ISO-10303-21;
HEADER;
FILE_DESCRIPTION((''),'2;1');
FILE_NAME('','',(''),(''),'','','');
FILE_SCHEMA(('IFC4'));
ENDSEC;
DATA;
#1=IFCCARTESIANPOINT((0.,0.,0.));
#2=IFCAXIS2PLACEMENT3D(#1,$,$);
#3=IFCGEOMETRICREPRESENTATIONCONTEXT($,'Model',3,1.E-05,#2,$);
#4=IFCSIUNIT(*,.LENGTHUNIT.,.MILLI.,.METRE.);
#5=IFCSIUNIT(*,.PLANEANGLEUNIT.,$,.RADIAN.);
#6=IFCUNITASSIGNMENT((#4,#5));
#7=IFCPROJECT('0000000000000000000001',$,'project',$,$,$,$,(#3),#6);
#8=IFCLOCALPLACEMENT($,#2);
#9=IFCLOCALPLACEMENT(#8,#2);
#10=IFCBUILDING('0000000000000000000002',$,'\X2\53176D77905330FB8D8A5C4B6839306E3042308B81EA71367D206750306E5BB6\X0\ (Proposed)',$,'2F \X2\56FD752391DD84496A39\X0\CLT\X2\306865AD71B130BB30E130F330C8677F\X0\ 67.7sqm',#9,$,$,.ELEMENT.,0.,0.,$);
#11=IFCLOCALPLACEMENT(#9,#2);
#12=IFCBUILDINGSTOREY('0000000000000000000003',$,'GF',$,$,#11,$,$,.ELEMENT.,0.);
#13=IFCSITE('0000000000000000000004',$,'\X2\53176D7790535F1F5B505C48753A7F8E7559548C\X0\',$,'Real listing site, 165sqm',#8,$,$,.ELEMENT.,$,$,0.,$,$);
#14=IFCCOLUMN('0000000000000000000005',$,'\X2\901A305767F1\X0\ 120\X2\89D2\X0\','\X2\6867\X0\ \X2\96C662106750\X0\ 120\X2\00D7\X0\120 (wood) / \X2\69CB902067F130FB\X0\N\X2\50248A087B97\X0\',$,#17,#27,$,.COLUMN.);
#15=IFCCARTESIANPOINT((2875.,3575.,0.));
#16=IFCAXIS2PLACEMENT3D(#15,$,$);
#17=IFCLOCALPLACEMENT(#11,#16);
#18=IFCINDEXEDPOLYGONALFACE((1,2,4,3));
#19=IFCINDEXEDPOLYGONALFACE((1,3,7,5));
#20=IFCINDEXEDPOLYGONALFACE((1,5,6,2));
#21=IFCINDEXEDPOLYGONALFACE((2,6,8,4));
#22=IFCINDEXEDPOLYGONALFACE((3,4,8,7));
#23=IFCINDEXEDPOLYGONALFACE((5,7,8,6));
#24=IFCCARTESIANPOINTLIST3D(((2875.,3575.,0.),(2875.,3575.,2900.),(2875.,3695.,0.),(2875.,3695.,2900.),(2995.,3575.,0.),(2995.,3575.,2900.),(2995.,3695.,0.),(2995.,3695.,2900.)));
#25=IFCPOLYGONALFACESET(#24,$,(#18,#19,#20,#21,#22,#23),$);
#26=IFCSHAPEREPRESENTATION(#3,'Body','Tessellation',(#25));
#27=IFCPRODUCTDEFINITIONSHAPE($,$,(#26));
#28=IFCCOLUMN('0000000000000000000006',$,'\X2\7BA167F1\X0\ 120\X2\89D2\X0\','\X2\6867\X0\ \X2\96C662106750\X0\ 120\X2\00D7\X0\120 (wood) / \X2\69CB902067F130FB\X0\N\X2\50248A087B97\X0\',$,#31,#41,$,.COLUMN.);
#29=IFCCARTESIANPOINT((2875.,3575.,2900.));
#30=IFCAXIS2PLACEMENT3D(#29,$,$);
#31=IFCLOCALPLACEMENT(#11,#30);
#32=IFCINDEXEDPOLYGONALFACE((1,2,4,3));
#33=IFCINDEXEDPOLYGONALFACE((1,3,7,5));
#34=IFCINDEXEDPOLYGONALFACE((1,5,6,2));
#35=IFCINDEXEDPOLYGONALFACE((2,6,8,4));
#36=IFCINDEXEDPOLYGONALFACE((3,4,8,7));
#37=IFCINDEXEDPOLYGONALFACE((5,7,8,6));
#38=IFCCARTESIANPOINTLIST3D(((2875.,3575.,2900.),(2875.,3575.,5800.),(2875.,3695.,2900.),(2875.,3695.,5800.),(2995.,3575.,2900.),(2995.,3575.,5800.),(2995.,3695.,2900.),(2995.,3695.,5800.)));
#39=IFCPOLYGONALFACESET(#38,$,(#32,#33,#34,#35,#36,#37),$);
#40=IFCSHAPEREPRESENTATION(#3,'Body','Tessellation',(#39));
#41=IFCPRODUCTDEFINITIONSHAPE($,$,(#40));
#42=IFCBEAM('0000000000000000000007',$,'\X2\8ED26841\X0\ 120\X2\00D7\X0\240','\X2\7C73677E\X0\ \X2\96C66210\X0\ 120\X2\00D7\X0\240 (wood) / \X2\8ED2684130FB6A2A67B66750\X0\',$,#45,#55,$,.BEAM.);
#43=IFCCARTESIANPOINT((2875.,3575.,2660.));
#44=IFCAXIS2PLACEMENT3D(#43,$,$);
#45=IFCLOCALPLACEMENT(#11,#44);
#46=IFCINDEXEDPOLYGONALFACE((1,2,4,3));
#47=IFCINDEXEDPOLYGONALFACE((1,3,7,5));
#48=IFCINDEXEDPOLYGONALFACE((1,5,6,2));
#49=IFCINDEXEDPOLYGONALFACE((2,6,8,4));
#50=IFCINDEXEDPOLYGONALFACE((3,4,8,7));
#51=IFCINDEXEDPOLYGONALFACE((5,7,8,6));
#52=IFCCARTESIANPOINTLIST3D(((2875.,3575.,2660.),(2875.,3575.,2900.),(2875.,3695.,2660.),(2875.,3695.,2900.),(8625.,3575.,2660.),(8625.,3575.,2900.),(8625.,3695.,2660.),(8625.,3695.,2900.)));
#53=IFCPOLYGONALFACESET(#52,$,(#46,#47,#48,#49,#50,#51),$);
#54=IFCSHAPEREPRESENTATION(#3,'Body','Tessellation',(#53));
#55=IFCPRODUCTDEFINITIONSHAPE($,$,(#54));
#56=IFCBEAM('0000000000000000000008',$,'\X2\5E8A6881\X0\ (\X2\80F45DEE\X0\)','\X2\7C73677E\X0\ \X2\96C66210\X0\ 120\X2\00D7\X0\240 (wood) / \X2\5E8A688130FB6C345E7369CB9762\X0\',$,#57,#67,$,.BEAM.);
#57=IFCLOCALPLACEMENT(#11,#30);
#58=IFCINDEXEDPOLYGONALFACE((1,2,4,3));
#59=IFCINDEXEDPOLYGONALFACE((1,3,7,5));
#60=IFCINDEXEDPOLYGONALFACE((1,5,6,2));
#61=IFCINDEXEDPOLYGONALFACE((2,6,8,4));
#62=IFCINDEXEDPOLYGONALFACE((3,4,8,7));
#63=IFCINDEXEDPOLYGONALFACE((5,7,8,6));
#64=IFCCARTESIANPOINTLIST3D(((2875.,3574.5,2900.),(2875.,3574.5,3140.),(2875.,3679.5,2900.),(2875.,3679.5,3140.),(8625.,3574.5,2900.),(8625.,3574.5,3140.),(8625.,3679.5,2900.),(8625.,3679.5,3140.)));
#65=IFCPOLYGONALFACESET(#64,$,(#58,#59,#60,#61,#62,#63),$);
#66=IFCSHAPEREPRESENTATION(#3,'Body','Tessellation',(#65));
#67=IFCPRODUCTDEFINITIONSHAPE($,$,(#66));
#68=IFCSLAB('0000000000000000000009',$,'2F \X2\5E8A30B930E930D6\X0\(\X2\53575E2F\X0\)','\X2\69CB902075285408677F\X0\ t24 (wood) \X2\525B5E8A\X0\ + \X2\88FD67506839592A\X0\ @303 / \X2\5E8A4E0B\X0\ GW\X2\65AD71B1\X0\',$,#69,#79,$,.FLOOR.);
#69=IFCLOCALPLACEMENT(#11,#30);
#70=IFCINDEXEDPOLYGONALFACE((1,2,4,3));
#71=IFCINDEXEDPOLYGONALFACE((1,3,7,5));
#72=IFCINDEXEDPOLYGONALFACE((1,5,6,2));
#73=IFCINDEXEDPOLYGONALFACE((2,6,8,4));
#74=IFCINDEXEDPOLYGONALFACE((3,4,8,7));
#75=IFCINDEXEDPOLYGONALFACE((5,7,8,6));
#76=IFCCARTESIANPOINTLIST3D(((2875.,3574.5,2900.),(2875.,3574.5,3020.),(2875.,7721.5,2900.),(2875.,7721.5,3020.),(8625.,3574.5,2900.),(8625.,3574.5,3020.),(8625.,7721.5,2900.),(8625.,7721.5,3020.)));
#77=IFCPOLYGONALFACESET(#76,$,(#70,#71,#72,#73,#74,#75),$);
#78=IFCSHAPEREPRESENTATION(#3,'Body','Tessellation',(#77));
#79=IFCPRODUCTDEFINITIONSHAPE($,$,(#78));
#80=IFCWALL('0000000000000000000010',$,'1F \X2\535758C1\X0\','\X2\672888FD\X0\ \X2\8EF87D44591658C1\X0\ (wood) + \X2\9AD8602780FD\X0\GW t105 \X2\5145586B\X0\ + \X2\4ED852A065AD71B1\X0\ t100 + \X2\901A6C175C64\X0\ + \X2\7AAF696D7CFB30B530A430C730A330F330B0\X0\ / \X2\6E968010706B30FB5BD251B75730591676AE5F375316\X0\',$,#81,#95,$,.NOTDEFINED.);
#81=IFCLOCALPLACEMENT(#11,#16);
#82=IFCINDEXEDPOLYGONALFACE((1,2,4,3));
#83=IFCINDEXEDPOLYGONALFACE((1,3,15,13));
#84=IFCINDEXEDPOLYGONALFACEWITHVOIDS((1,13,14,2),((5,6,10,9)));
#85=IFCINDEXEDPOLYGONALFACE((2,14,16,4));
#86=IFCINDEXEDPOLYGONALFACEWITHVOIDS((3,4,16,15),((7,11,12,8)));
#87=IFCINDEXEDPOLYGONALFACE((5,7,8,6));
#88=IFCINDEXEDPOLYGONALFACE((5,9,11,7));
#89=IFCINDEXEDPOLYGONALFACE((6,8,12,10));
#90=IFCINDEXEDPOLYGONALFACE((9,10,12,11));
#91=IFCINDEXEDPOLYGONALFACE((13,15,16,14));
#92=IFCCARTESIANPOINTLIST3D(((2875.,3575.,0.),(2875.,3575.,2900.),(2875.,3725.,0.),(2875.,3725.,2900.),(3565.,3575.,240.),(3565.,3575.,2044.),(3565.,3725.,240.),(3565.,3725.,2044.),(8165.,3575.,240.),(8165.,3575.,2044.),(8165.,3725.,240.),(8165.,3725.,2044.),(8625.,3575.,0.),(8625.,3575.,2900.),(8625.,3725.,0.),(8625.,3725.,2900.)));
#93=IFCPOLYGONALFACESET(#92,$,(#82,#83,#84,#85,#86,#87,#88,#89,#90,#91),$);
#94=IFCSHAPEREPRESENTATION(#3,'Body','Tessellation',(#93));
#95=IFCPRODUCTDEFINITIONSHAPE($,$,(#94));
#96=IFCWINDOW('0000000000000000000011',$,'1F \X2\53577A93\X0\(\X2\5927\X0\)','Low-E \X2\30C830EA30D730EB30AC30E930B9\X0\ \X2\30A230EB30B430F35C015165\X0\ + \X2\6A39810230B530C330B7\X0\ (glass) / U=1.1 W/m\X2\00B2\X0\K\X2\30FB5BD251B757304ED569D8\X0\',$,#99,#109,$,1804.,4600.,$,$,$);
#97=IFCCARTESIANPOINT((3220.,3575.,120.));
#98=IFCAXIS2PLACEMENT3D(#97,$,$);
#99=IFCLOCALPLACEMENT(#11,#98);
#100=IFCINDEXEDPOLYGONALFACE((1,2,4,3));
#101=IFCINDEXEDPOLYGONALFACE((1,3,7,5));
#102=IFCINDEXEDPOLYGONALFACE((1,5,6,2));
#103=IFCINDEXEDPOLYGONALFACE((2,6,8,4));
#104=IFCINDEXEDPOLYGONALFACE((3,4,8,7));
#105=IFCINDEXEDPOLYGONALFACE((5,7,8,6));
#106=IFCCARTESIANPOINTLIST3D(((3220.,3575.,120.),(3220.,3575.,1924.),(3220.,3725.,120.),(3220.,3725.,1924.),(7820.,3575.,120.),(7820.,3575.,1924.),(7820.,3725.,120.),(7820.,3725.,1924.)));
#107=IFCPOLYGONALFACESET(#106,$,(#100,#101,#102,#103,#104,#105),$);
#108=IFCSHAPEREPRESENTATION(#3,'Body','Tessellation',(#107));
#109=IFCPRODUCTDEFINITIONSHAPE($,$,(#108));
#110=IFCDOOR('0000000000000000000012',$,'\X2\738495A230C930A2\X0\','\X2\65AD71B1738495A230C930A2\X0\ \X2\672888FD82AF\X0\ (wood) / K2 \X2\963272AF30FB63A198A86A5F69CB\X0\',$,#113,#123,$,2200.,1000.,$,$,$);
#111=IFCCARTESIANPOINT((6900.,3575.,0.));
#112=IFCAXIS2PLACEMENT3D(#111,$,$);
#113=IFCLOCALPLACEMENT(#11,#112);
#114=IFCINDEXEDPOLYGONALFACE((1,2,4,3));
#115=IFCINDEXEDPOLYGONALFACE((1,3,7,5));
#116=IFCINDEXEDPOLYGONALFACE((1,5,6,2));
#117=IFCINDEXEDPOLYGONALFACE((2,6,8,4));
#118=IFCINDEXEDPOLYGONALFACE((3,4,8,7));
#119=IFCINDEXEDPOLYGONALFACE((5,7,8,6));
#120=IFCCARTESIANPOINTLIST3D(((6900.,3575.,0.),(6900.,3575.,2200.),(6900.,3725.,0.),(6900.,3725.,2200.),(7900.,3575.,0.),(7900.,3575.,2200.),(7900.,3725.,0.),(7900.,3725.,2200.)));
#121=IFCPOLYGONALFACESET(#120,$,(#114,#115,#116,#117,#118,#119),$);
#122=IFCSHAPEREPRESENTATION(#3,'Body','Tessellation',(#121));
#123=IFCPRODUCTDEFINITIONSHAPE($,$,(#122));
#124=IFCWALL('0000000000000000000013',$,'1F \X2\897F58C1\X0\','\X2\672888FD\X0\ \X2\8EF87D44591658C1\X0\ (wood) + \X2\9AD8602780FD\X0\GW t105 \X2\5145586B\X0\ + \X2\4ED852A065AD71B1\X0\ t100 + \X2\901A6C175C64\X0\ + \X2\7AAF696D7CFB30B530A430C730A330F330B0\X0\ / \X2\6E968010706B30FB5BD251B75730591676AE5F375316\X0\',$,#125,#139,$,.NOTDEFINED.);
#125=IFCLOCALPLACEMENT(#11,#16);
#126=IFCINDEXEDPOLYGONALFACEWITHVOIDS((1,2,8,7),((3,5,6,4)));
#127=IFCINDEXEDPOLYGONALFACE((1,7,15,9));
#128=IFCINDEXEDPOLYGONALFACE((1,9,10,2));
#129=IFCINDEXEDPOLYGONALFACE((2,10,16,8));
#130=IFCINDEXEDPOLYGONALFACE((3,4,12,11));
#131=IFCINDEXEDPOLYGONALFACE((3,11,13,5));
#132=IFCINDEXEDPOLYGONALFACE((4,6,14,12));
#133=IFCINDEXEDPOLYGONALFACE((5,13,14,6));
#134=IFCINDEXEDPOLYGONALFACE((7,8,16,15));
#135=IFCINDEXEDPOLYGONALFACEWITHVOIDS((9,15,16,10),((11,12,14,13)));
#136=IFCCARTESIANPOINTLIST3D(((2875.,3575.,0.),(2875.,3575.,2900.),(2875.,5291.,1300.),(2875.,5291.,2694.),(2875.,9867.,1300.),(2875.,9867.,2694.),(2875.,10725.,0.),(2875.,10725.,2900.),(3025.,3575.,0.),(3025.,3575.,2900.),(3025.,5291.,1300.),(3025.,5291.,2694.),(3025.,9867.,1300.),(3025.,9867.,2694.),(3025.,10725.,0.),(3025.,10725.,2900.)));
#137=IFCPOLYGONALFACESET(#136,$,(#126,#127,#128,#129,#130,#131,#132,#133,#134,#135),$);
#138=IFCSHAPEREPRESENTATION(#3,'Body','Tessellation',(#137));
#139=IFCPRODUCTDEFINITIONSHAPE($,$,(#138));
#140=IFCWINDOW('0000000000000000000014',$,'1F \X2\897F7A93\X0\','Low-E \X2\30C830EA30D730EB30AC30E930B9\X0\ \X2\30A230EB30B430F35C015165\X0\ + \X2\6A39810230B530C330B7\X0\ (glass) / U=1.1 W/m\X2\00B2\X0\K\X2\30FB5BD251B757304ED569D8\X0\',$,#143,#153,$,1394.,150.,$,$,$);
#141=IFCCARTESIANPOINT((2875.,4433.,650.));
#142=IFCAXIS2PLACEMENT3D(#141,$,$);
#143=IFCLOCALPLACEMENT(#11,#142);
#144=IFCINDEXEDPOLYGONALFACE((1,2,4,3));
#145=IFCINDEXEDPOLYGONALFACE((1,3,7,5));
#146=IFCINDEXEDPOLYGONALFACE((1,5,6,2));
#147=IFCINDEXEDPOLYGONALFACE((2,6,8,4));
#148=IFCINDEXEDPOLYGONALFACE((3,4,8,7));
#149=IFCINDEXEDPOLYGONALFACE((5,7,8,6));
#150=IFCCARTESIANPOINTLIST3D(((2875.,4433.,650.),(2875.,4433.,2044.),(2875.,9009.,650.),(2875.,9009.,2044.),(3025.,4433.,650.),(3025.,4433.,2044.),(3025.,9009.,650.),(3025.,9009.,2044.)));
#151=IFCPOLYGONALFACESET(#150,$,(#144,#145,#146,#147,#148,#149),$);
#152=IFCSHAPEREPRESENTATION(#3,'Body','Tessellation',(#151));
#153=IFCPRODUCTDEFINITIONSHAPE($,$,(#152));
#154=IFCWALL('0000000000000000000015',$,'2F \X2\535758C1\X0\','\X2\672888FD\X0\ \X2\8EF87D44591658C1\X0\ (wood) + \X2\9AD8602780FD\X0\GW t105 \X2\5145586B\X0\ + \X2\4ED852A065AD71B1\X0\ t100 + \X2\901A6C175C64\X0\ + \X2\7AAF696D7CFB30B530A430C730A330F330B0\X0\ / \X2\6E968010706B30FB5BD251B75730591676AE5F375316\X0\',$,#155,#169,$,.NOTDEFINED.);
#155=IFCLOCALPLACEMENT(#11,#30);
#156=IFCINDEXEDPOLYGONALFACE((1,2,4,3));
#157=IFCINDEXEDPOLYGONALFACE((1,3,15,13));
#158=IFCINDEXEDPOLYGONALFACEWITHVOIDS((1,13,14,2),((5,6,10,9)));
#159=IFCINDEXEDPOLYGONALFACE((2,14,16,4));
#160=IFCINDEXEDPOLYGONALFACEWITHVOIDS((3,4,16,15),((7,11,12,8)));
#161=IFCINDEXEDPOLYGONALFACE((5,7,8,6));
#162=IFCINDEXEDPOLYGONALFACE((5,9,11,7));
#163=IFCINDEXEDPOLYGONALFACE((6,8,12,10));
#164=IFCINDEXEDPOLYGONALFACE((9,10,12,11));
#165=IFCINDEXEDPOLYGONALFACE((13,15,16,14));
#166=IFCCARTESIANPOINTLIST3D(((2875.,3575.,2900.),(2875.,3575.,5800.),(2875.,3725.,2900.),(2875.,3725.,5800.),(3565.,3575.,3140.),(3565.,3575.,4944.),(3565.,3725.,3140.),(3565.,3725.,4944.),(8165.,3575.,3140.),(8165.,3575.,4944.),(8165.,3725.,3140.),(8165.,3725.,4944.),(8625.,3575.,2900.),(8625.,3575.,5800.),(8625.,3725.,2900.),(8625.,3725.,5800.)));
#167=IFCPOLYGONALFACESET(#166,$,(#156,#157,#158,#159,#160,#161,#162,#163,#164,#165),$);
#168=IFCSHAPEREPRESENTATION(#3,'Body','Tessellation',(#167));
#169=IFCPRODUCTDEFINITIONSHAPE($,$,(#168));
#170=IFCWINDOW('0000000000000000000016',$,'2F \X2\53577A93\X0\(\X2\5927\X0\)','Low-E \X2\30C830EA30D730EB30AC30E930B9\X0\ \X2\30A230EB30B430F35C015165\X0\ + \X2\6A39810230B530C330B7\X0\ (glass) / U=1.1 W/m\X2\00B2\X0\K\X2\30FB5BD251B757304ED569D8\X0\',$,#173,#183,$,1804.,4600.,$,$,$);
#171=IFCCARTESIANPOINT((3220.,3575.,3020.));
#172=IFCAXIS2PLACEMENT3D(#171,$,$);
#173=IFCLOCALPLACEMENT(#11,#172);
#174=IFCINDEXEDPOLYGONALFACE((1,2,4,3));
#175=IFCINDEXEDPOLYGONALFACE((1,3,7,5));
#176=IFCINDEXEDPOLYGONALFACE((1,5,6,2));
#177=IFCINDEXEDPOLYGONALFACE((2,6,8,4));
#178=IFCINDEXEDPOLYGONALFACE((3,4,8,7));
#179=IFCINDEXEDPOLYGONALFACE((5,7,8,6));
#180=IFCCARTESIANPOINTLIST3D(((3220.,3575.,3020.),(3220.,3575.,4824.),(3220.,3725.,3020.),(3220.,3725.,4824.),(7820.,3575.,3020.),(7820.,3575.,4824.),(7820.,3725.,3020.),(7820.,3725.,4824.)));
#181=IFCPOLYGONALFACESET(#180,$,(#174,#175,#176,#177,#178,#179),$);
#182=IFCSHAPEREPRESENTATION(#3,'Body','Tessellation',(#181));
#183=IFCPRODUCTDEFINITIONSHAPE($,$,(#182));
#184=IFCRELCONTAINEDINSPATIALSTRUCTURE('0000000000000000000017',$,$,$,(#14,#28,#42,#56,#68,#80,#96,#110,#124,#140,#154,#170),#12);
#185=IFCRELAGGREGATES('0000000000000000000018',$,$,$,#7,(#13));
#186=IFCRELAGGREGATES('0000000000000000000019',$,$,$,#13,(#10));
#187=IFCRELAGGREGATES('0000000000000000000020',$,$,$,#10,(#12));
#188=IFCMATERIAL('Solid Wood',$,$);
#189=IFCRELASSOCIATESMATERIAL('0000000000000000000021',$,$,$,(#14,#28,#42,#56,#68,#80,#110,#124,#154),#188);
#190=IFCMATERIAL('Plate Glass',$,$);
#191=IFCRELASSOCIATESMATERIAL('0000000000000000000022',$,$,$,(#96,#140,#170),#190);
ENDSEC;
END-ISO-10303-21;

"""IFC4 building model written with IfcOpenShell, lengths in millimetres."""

from ifc_helpers import new_model, si_unit, frame, frame_2d, origin, place, context, project, spatial, rectangle, extrude, material, element, fill, save


model = new_model("IFC4")

# Units and contexts
model_context = context("Model", 3, precision=1e-05, world=origin())
ifc_project = project(units=[si_unit("LENGTHUNIT", "METRE", prefix="MILLI"), si_unit("PLANEANGLEUNIT", "RADIAN")], contexts=[model_context])

# Site, building, storey
site_placement = place(None, origin())
site = spatial("IfcSite", under=ifc_project, at=site_placement, Name="北海道弟子屈町美留和", ObjectType="Real listing site, 165sqm", CompositionType="ELEMENT", RefElevation=0.0)
building_placement = place(site_placement, origin())
building = spatial("IfcBuilding", under=site, at=building_placement, Name="北海道・越屋根のある自然素材の家 (Proposed)", ObjectType="2F 国産針葉樹CLTと断熱セメント板 67.7sqm", CompositionType="ELEMENT", ElevationOfRefHeight=0.0, ElevationOfTerrain=0.0)
storey_placement = place(building_placement, origin())
storey = spatial("IfcBuildingStorey", under=building, at=storey_placement, Name="GF", CompositionType="ELEMENT", Elevation=0.0)

# Columns
ifc_material_1 = material(Name="Solid Wood")
column_1_placement = place(storey_placement, frame((2875.0, 3575.0, 0.0)))
element("IfcColumn", 1, at=column_1_placement, inside=storey, material=ifc_material_1, Name="通し柱 120角", Description="桧 集成材 120×120 (wood) / 構造柱・N値計算", PredefinedType="COLUMN", context=model_context, shape_type="SweptSolid", body=[
    extrude(rectangle(XDim=120.0, YDim=120.0, at=frame_2d((60.0, 60.0))), frame((2875.0, 3575.0, 0.0)), (0.0, 0.0, 1.0), 2900.0),
])
column_2_placement = place(storey_placement, frame((2875.0, 3575.0, 2900.0)))
element("IfcColumn", 2, at=column_2_placement, inside=storey, material=ifc_material_1, Name="管柱 120角", Description="桧 集成材 120×120 (wood) / 構造柱・N値計算", PredefinedType="COLUMN", context=model_context, shape_type="SweptSolid", body=[
    extrude(rectangle(XDim=120.0, YDim=120.0, at=frame_2d((60.0, 60.0))), frame((2875.0, 3575.0, 2900.0)), (0.0, 0.0, 1.0), 2900.0),
])

# Beams
beam_1_placement = place(storey_placement, frame((2875.0, 3575.0, 2660.0)))
element("IfcBeam", 3, at=beam_1_placement, inside=storey, material=ifc_material_1, Name="軒桁 120×240", Description="米松 集成 120×240 (wood) / 軒桁・横架材", PredefinedType="BEAM", context=model_context, shape_type="SweptSolid", body=[
    extrude(rectangle(XDim=5750.0, YDim=120.0, at=frame_2d((2875.0, 60.0))), frame((2875.0, 3575.0, 2660.0)), (0.0, 0.0, 1.0), 240.0),
])
beam_2_placement = place(storey_placement, frame((2875.0, 3575.0, 2900.0)))
element("IfcBeam", 4, at=beam_2_placement, inside=storey, material=ifc_material_1, Name="床梁 (胴差)", Description="米松 集成 120×240 (wood) / 床梁・水平構面", PredefinedType="BEAM", context=model_context, shape_type="SweptSolid", body=[
    extrude(rectangle(XDim=5750.0, YDim=105.0, at=frame_2d((2875.0, 52.0))), frame((2875.0, 3575.0, 2900.0)), (0.0, 0.0, 1.0), 240.0),
])

# Slab
slab_1_placement = place(storey_placement, frame((2875.0, 3575.0, 2900.0)))
element("IfcSlab", 5, at=slab_1_placement, inside=storey, material=ifc_material_1, Name="2F 床スラブ(南帯)", Description="構造用合板 t24 (wood) 剛床 + 製材根太 @303 / 床下 GW断熱", PredefinedType="FLOOR", context=model_context, shape_type="SweptSolid", body=[
    extrude(rectangle(XDim=5750.0, YDim=4147.0, at=frame_2d((2875.0, 2073.0))), frame((2875.0, 3575.0, 2900.0)), (0.0, 0.0, 1.0), 120.0),
])

# Wall, openings, window, door
wall_1_placement = place(storey_placement, frame((2875.0, 3575.0, 0.0)))
wall_1 = element("IfcWall", 6, at=wall_1_placement, inside=storey, material=ifc_material_1, Name="1F 南壁", Description="木製 軸組外壁 (wood) + 高性能GW t105 充填 + 付加断熱 t100 + 通気層 + 窯業系サイディング / 準耐火・寒冷地外皮強化", PredefinedType="NOTDEFINED", context=model_context, shape_type="SweptSolid", body=[
    extrude(rectangle(XDim=5750.0, YDim=150.0, at=frame_2d((2875.0, 75.0))), frame((2875.0, 3575.0, 0.0)), (0.0, 0.0, 1.0), 2900.0),
])
opening_1_placement = place(storey_placement, frame((3220.0, 3575.0, 120.0)))
opening_1 = element("IfcOpeningElement", 7, at=opening_1_placement, cuts=wall_1, PredefinedType="NOTDEFINED", context=model_context, shape_type="SweptSolid", body=[
    extrude(rectangle(XDim=4600.0, YDim=150.0, at=frame_2d((2300.0, 75.0))), frame((3220.0, 3575.0, 120.0)), (0.0, 0.0, 1.0), 1804.0),
])
opening_2_placement = place(storey_placement, frame((6900.0, 3575.0, 0.0)))
opening_2 = element("IfcOpeningElement", 8, at=opening_2_placement, cuts=wall_1, PredefinedType="NOTDEFINED", context=model_context, shape_type="SweptSolid", body=[
    extrude(rectangle(XDim=1000.0, YDim=150.0, at=frame_2d((500.0, 75.0))), frame((6900.0, 3575.0, 0.0)), (0.0, 0.0, 1.0), 2200.0),
])
ifc_material_2 = material(Name="Plate Glass")
window_1_placement = place(storey_placement, frame((3220.0, 3575.0, 120.0)))
window_1 = element("IfcWindow", 9, at=window_1_placement, inside=storey, material=ifc_material_2, Name="1F 南窓(大)", Description="Low-E トリプルガラス アルゴン封入 + 樹脂サッシ (glass) / U=1.1 W/m²K・寒冷地仕様", OverallHeight=1804.0, OverallWidth=4600.0, context=model_context, shape_type="SweptSolid", body=[
    extrude(rectangle(XDim=4600.0, YDim=150.0, at=frame_2d((2300.0, 75.0))), frame((3220.0, 3575.0, 120.0)), (0.0, 0.0, 1.0), 1804.0),
])
fill(opening_1, window_1)
door_placement = place(storey_placement, frame((6900.0, 3575.0, 0.0)))
door = element("IfcDoor", 10, at=door_placement, inside=storey, material=ifc_material_1, Name="玄関ドア", Description="断熱玄関ドア 木製芯 (wood) / K2 防犯・採風機構", OverallHeight=2200.0, OverallWidth=1000.0, context=model_context, shape_type="SweptSolid", body=[
    extrude(rectangle(XDim=1000.0, YDim=150.0, at=frame_2d((500.0, 75.0))), frame((6900.0, 3575.0, 0.0)), (0.0, 0.0, 1.0), 2200.0),
])
fill(opening_2, door)

# Walls, openings, windows
wall_2_placement = place(storey_placement, frame((2875.0, 3575.0, 0.0)))
wall_2 = element("IfcWall", 11, at=wall_2_placement, inside=storey, material=ifc_material_1, Name="1F 西壁", Description="木製 軸組外壁 (wood) + 高性能GW t105 充填 + 付加断熱 t100 + 通気層 + 窯業系サイディング / 準耐火・寒冷地外皮強化", PredefinedType="NOTDEFINED", context=model_context, shape_type="SweptSolid", body=[
    extrude(rectangle(XDim=150.0, YDim=7150.0, at=frame_2d((75.0, 3575.0))), frame((2875.0, 3575.0, 0.0)), (0.0, 0.0, 1.0), 2900.0),
])
opening_3_placement = place(storey_placement, frame((2875.0, 4433.0, 650.0)))
opening_3 = element("IfcOpeningElement", 12, at=opening_3_placement, cuts=wall_2, PredefinedType="NOTDEFINED", context=model_context, shape_type="SweptSolid", body=[
    extrude(rectangle(XDim=150.0, YDim=4576.0, at=frame_2d((75.0, 2288.0))), frame((2875.0, 4433.0, 650.0)), (0.0, 0.0, 1.0), 1394.0),
])
window_2_placement = place(storey_placement, frame((2875.0, 4433.0, 650.0)))
window_2 = element("IfcWindow", 13, at=window_2_placement, inside=storey, material=ifc_material_2, Name="1F 西窓", Description="Low-E トリプルガラス アルゴン封入 + 樹脂サッシ (glass) / U=1.1 W/m²K・寒冷地仕様", OverallHeight=1394.0, OverallWidth=150.0, context=model_context, shape_type="SweptSolid", body=[
    extrude(rectangle(XDim=150.0, YDim=4576.0, at=frame_2d((75.0, 2288.0))), frame((2875.0, 4433.0, 650.0)), (0.0, 0.0, 1.0), 1394.0),
])
fill(opening_3, window_2)
wall_3_placement = place(storey_placement, frame((2875.0, 3575.0, 2900.0)))
wall_3 = element("IfcWall", 14, at=wall_3_placement, inside=storey, material=ifc_material_1, Name="2F 南壁", Description="木製 軸組外壁 (wood) + 高性能GW t105 充填 + 付加断熱 t100 + 通気層 + 窯業系サイディング / 準耐火・寒冷地外皮強化", PredefinedType="NOTDEFINED", context=model_context, shape_type="SweptSolid", body=[
    extrude(rectangle(XDim=5750.0, YDim=150.0, at=frame_2d((2875.0, 75.0))), frame((2875.0, 3575.0, 2900.0)), (0.0, 0.0, 1.0), 2900.0),
])
opening_4_placement = place(storey_placement, frame((3220.0, 3575.0, 3020.0)))
opening_4 = element("IfcOpeningElement", 15, at=opening_4_placement, cuts=wall_3, PredefinedType="NOTDEFINED", context=model_context, shape_type="SweptSolid", body=[
    extrude(rectangle(XDim=4600.0, YDim=150.0, at=frame_2d((2300.0, 75.0))), frame((3220.0, 3575.0, 3020.0)), (0.0, 0.0, 1.0), 1804.0),
])
window_3_placement = place(storey_placement, frame((3220.0, 3575.0, 3020.0)))
window_3 = element("IfcWindow", 16, at=window_3_placement, inside=storey, material=ifc_material_2, Name="2F 南窓(大)", Description="Low-E トリプルガラス アルゴン封入 + 樹脂サッシ (glass) / U=1.1 W/m²K・寒冷地仕様", OverallHeight=1804.0, OverallWidth=4600.0, context=model_context, shape_type="SweptSolid", body=[
    extrude(rectangle(XDim=4600.0, YDim=150.0, at=frame_2d((2300.0, 75.0))), frame((3220.0, 3575.0, 3020.0)), (0.0, 0.0, 1.0), 1804.0),
])
fill(opening_4, window_3)

save(model, "model.ifc")
